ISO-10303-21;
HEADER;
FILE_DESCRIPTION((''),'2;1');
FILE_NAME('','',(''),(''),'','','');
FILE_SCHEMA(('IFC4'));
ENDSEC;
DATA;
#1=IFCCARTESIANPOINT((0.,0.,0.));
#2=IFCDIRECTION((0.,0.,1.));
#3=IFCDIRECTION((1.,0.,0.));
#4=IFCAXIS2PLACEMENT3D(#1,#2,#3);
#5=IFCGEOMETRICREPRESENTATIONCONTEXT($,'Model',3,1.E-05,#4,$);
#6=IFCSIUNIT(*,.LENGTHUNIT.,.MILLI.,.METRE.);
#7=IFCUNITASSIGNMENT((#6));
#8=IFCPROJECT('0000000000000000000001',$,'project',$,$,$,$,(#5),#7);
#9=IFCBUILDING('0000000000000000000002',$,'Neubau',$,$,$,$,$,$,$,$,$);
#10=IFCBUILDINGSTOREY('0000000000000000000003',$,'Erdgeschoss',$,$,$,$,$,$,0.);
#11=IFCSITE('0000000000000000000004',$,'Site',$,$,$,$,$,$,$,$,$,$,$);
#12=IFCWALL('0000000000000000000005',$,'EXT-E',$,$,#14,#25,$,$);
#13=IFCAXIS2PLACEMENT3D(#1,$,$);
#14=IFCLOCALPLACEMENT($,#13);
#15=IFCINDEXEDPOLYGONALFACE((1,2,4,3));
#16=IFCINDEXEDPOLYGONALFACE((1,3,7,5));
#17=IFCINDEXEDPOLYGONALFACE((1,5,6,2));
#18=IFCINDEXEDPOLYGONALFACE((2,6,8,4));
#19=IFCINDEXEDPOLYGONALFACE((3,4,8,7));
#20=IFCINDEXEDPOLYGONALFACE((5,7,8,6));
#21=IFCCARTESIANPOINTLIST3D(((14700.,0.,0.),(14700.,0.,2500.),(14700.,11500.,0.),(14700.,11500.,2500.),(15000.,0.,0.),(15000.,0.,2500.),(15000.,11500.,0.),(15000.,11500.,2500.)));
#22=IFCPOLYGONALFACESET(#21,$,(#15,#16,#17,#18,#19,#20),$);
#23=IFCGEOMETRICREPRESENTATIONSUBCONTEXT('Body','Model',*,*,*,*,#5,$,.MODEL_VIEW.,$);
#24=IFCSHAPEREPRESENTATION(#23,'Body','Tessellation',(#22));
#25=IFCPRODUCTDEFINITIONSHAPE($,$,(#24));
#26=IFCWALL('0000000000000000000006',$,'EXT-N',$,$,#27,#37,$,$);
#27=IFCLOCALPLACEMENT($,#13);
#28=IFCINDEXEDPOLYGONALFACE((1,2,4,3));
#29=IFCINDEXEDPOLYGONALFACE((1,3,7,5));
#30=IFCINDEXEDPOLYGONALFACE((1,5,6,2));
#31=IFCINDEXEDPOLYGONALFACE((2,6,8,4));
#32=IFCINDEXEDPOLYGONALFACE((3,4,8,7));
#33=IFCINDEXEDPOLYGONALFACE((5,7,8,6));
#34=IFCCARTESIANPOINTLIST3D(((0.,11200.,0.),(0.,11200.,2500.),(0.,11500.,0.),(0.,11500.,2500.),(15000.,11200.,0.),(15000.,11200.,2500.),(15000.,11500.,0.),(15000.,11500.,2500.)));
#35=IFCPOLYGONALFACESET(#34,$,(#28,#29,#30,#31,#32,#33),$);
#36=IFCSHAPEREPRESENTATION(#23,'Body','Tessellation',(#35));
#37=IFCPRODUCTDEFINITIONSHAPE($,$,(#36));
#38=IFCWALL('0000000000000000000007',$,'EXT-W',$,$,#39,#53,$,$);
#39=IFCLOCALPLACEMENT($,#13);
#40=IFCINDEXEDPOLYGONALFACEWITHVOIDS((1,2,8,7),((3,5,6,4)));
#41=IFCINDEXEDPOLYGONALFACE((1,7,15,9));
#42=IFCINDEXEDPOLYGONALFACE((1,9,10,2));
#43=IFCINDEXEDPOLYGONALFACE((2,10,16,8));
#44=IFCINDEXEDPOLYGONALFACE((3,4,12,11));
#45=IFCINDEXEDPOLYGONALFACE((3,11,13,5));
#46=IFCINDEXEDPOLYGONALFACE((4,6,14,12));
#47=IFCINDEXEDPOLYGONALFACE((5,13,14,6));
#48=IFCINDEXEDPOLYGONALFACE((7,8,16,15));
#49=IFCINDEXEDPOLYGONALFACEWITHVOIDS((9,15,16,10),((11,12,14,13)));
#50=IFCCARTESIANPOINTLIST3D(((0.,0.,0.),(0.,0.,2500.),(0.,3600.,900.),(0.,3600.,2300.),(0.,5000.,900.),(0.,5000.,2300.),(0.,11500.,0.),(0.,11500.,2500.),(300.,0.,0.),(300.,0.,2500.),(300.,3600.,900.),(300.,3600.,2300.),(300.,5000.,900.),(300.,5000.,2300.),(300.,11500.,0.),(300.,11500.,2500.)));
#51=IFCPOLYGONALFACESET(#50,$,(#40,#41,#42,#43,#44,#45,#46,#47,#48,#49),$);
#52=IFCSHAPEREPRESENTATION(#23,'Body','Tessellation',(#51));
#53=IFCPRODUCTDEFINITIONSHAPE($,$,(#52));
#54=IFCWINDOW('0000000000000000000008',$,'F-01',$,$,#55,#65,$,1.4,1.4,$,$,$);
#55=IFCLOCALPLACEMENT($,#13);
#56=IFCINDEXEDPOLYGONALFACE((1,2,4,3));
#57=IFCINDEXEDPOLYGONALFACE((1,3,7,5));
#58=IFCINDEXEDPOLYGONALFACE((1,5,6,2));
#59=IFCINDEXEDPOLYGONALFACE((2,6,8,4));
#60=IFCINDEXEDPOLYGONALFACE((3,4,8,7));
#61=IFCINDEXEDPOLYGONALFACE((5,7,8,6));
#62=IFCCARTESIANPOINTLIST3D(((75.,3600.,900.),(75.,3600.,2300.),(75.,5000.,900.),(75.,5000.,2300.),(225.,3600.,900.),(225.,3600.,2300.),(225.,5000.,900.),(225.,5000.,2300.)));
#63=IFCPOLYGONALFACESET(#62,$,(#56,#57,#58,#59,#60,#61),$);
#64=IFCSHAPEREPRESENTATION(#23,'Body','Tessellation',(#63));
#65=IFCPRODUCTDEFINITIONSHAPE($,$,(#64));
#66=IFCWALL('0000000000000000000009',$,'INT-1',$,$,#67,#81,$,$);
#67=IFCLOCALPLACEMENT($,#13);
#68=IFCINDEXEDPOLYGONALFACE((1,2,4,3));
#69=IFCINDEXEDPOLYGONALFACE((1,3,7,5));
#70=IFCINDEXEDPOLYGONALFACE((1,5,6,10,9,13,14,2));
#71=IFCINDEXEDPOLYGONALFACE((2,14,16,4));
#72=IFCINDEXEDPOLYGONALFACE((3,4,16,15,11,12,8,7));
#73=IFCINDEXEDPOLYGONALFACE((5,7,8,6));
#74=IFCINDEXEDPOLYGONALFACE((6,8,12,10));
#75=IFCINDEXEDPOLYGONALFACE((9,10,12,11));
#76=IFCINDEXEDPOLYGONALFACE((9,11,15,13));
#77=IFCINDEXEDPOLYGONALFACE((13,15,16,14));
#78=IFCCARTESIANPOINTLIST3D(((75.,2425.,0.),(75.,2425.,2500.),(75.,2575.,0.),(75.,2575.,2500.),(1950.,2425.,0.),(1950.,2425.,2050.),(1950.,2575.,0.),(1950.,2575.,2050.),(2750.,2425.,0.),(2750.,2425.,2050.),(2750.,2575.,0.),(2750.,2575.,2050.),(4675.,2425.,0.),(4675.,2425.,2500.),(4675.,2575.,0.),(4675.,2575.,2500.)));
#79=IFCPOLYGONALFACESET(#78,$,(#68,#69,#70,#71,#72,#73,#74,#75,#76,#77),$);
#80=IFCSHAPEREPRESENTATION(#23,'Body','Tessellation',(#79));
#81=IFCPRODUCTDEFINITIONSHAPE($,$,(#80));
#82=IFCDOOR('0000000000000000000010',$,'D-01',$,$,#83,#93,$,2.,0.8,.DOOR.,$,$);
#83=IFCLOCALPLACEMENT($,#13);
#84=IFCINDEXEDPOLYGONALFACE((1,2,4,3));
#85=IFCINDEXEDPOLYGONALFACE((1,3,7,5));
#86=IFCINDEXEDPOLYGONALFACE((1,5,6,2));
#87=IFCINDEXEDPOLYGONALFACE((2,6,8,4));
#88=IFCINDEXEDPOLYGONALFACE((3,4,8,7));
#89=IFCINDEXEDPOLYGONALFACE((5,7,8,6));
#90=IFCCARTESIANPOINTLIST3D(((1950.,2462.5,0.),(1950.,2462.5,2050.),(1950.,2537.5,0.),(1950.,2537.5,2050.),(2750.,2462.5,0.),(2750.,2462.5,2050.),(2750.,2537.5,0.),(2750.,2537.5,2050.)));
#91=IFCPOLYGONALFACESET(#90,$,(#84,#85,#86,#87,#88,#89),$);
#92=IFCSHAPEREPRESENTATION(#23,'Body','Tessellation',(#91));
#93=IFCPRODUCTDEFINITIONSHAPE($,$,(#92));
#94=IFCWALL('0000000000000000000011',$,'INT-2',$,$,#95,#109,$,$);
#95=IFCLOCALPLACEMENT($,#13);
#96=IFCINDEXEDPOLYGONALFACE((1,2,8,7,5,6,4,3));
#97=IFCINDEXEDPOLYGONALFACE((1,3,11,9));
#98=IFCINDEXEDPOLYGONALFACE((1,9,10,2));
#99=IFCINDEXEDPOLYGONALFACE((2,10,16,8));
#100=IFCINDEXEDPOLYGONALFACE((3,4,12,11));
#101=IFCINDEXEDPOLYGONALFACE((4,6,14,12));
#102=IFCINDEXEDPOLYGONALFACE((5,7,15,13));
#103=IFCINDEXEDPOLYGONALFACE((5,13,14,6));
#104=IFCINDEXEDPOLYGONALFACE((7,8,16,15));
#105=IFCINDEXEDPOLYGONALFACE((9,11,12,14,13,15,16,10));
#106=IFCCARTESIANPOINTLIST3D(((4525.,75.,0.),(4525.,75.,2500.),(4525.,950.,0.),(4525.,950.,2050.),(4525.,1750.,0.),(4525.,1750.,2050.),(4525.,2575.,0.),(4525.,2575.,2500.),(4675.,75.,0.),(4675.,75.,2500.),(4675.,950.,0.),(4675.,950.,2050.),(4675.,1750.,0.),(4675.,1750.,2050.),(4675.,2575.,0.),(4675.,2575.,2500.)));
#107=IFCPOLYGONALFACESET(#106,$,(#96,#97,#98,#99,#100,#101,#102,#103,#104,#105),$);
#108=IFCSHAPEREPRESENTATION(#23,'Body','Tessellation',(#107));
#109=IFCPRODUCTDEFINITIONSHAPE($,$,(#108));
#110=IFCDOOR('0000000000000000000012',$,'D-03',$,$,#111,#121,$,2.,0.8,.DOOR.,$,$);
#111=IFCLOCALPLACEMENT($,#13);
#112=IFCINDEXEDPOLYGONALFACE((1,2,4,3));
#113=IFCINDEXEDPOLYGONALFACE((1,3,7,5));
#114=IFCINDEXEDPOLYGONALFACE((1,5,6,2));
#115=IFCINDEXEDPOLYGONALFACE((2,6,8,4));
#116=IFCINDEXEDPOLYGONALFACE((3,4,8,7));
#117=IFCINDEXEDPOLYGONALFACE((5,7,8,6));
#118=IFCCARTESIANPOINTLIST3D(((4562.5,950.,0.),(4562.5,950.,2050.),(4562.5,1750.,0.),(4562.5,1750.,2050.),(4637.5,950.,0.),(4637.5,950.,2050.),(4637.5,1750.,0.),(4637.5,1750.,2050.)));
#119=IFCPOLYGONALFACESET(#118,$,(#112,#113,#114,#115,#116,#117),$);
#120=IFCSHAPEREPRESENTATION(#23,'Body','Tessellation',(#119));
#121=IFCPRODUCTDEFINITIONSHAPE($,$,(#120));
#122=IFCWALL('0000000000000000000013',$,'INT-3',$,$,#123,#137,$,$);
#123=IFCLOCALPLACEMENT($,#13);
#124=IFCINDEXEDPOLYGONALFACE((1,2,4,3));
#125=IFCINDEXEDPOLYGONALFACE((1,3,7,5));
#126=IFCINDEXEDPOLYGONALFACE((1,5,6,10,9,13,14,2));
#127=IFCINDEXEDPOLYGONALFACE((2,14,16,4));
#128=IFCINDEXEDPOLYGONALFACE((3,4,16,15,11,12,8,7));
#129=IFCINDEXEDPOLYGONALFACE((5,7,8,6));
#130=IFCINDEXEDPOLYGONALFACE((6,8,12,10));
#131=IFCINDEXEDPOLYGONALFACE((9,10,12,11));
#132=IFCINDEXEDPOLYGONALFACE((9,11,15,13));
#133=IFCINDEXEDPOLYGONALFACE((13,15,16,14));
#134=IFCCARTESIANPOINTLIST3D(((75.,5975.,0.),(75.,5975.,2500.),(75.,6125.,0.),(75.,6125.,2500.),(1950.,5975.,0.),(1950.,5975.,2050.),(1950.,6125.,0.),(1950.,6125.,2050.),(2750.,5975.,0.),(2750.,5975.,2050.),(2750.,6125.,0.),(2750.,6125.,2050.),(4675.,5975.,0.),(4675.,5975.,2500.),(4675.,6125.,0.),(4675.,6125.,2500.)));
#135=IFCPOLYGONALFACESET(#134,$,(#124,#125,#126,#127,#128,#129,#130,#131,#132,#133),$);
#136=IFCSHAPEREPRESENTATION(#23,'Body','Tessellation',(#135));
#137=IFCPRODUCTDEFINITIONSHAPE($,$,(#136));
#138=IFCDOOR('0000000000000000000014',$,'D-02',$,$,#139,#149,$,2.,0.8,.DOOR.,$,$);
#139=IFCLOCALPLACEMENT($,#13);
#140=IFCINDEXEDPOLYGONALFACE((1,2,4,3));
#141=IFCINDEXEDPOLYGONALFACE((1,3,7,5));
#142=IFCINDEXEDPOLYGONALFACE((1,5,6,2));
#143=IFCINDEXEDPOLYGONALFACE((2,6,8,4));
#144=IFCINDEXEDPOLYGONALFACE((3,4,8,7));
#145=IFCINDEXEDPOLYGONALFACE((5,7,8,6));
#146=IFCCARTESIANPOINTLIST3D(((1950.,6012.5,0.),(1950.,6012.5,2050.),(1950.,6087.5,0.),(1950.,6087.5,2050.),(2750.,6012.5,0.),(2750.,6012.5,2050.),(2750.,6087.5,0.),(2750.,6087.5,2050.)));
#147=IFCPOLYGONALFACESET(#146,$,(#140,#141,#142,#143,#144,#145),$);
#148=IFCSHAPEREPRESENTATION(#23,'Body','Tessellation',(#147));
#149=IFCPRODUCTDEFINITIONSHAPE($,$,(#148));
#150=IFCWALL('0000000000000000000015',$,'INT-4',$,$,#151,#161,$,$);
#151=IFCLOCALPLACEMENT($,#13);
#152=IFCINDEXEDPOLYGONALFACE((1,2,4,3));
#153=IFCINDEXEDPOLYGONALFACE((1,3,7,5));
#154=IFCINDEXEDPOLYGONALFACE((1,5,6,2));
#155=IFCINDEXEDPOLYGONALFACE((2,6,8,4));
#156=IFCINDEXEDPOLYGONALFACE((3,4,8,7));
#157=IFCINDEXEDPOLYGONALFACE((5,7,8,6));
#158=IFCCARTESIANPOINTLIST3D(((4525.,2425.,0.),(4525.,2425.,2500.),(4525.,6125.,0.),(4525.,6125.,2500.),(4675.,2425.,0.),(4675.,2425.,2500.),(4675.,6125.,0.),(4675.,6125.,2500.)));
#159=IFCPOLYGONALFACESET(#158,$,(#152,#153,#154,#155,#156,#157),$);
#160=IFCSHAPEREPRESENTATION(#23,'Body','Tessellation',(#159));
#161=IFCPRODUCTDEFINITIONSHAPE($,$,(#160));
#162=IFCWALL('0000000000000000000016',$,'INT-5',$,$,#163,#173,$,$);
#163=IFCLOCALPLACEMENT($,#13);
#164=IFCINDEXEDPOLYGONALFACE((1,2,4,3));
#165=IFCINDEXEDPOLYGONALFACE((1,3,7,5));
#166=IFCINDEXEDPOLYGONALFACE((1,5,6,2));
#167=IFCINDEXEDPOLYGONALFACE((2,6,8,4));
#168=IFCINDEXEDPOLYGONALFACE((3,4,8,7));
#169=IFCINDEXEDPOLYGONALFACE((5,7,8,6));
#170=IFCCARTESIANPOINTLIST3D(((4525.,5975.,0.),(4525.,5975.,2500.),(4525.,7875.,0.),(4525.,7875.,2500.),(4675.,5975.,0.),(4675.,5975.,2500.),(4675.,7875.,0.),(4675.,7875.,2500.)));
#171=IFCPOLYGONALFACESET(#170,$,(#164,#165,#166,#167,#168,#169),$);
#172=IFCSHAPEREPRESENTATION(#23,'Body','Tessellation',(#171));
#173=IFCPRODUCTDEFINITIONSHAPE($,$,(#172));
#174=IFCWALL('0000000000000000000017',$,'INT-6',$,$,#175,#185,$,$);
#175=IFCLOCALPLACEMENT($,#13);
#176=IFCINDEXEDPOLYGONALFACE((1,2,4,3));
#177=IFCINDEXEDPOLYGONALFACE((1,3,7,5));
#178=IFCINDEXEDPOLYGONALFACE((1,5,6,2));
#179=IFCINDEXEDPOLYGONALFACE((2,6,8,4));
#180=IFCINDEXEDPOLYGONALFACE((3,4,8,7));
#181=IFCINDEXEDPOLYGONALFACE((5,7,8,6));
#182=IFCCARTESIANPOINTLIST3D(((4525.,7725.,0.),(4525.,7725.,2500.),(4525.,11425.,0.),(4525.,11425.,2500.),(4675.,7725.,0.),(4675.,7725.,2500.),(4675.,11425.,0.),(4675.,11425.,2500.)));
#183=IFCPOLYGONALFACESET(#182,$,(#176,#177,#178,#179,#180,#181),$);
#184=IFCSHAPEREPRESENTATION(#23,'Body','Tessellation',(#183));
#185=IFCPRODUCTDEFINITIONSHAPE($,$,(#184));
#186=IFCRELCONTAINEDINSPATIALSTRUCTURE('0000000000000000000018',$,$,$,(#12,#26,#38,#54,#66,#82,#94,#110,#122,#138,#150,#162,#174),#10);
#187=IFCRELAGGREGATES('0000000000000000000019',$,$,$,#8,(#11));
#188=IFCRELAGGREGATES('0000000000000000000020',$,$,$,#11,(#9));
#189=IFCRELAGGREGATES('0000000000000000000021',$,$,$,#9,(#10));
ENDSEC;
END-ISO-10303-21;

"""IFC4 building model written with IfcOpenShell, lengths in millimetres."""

from ifc_helpers import new_model, si_unit, frame, origin_with_axes, place, context, subcontext, project, spatial, indexed_curve, outline, extrude, element, fill, save


model = new_model("IFC4")

# Units and contexts
model_context = context("Model", 3, precision=1e-05, world=origin_with_axes())
body_context = subcontext(model_context, "Body", "Model", "MODEL_VIEW")
ifc_project = project(units=[si_unit("LENGTHUNIT", "METRE", prefix="MILLI")], contexts=[model_context])

# Site, building, storey
site = spatial("IfcSite", under=ifc_project, Name="Site")
building = spatial("IfcBuilding", under=site, Name="Neubau")
storey = spatial("IfcBuildingStorey", under=building, Name="Erdgeschoss", Elevation=0.0)

# Walls
wall_1_placement = place(None, origin_with_axes())
element("IfcWall", 1, at=wall_1_placement, inside=storey, Name="EXT-E", context=body_context, shape_type="SweptSolid", body=[
    extrude(outline(indexed_curve([(14700.0, 0.0), (14700.0, 11500.0), (15000.0, 11500.0), (15000.0, 0.0), (14700.0, 0.0)])), origin_with_axes(), (0.0, 0.0, 1.0), 2500.0),
])
wall_2_placement = place(None, origin_with_axes())
element("IfcWall", 2, at=wall_2_placement, inside=storey, Name="EXT-N", context=body_context, shape_type="SweptSolid", body=[
    extrude(outline(indexed_curve([(15000.0, 11200.0), (0.0, 11200.0), (0.0, 11500.0), (15000.0, 11500.0), (15000.0, 11200.0)])), origin_with_axes(), (0.0, 0.0, 1.0), 2500.0),
])

# Wall, opening, window
wall_3_placement = place(None, origin_with_axes())
wall_3 = element("IfcWall", 3, at=wall_3_placement, inside=storey, Name="EXT-W", context=body_context, shape_type="SweptSolid", body=[
    extrude(outline(indexed_curve([(300.0, 11500.0), (300.0, 0.0), (0.0, 0.0), (0.0, 11500.0), (300.0, 11500.0)])), origin_with_axes(), (0.0, 0.0, 1.0), 2500.0),
])
opening_1_placement = place(wall_3_placement, frame((0.0, 0.0, 900.0), z_axis=(0.0, 0.0, 1.0), x_axis=(1.0, 0.0, 0.0)))
opening_1 = element("IfcOpeningElement", 4, at=opening_1_placement, cuts=wall_3, context=body_context, shape_type="SweptSolid", body=[
    extrude(outline(indexed_curve([(320.0, 5000.0), (320.0, 3600.0), (-20.0, 3600.0), (-20.0, 5000.0), (320.0, 5000.0)])), origin_with_axes(), (0.0, 0.0, 1.0), 1400.0),
])
window_1_placement = place(opening_1_placement, origin_with_axes())
window_1 = element("IfcWindow", 5, at=window_1_placement, inside=storey, Name="F-01", OverallHeight=1.4, OverallWidth=1.4, context=body_context, shape_type="SweptSolid", body=[
    extrude(outline(indexed_curve([(225.0, 5000.0), (225.0, 3600.0), (75.0, 3600.0), (75.0, 5000.0), (225.0, 5000.0)])), origin_with_axes(), (0.0, 0.0, 1.0), 1400.0),
])
fill(opening_1, window_1)

# Walls, openings, doors
wall_4_placement = place(None, origin_with_axes())
wall_4 = element("IfcWall", 6, at=wall_4_placement, inside=storey, Name="INT-1", context=body_context, shape_type="SweptSolid", body=[
    extrude(outline(indexed_curve([(75.0, 2575.0), (4675.0, 2575.0), (4675.0, 2425.0), (75.0, 2425.0), (75.0, 2575.0)])), origin_with_axes(), (0.0, 0.0, 1.0), 2500.0),
])
opening_2_placement = place(wall_4_placement, origin_with_axes())
opening_2 = element("IfcOpeningElement", 7, at=opening_2_placement, cuts=wall_4, context=body_context, shape_type="SweptSolid", body=[
    extrude(outline(indexed_curve([(1950.0, 2595.0), (2750.0, 2595.0), (2750.0, 2405.0), (1950.0, 2405.0), (1950.0, 2595.0)])), origin_with_axes(), (0.0, 0.0, 1.0), 2050.0),
])
door_1_placement = place(opening_2_placement, origin_with_axes())
door_1 = element("IfcDoor", 8, at=door_1_placement, inside=storey, Name="D-01", OverallHeight=2.0, OverallWidth=0.8, PredefinedType="DOOR", context=body_context, shape_type="SweptSolid", body=[
    extrude(outline(indexed_curve([(1950.0, 2537.5), (2750.0, 2537.5), (2750.0, 2462.5), (1950.0, 2462.5), (1950.0, 2537.5)])), origin_with_axes(), (0.0, 0.0, 1.0), 2050.0),
])
fill(opening_2, door_1)
wall_5_placement = place(None, origin_with_axes())
wall_5 = element("IfcWall", 9, at=wall_5_placement, inside=storey, Name="INT-2", context=body_context, shape_type="SweptSolid", body=[
    extrude(outline(indexed_curve([(4525.0, 75.0), (4525.0, 2575.0), (4675.0, 2575.0), (4675.0, 75.0), (4525.0, 75.0)])), origin_with_axes(), (0.0, 0.0, 1.0), 2500.0),
])
opening_3_placement = place(wall_5_placement, origin_with_axes())
opening_3 = element("IfcOpeningElement", 10, at=opening_3_placement, cuts=wall_5, context=body_context, shape_type="SweptSolid", body=[
    extrude(outline(indexed_curve([(4505.0, 950.0), (4505.0, 1750.0), (4695.0, 1750.0), (4695.0, 950.0), (4505.0, 950.0)])), origin_with_axes(), (0.0, 0.0, 1.0), 2050.0),
])
door_2_placement = place(opening_3_placement, origin_with_axes())
door_2 = element("IfcDoor", 11, at=door_2_placement, inside=storey, Name="D-03", OverallHeight=2.0, OverallWidth=0.8, PredefinedType="DOOR", context=body_context, shape_type="SweptSolid", body=[
    extrude(outline(indexed_curve([(4562.5, 950.0), (4562.5, 1750.0), (4637.5, 1750.0), (4637.5, 950.0), (4562.5, 950.0)])), origin_with_axes(), (0.0, 0.0, 1.0), 2050.0),
])
fill(opening_3, door_2)
wall_6_placement = place(None, origin_with_axes())
wall_6 = element("IfcWall", 12, at=wall_6_placement, inside=storey, Name="INT-3", context=body_context, shape_type="SweptSolid", body=[
    extrude(outline(indexed_curve([(75.0, 6125.0), (4675.0, 6125.0), (4675.0, 5975.0), (75.0, 5975.0), (75.0, 6125.0)])), origin_with_axes(), (0.0, 0.0, 1.0), 2500.0),
])
opening_4_placement = place(wall_6_placement, origin_with_axes())
opening_4 = element("IfcOpeningElement", 13, at=opening_4_placement, cuts=wall_6, context=body_context, shape_type="SweptSolid", body=[
    extrude(outline(indexed_curve([(1950.0, 6145.0), (2750.0, 6145.0), (2750.0, 5955.0), (1950.0, 5955.0), (1950.0, 6145.0)])), origin_with_axes(), (0.0, 0.0, 1.0), 2050.0),
])
door_3_placement = place(opening_4_placement, origin_with_axes())
door_3 = element("IfcDoor", 14, at=door_3_placement, inside=storey, Name="D-02", OverallHeight=2.0, OverallWidth=0.8, PredefinedType="DOOR", context=body_context, shape_type="SweptSolid", body=[
    extrude(outline(indexed_curve([(1950.0, 6087.5), (2750.0, 6087.5), (2750.0, 6012.5), (1950.0, 6012.5), (1950.0, 6087.5)])), origin_with_axes(), (0.0, 0.0, 1.0), 2050.0),
])
fill(opening_4, door_3)

# Walls
wall_7_placement = place(None, origin_with_axes())
element("IfcWall", 15, at=wall_7_placement, inside=storey, Name="INT-4", context=body_context, shape_type="SweptSolid", body=[
    extrude(outline(indexed_curve([(4525.0, 2425.0), (4525.0, 6125.0), (4675.0, 6125.0), (4675.0, 2425.0), (4525.0, 2425.0)])), origin_with_axes(), (0.0, 0.0, 1.0), 2500.0),
])
wall_8_placement = place(None, origin_with_axes())
element("IfcWall", 16, at=wall_8_placement, inside=storey, Name="INT-5", context=body_context, shape_type="SweptSolid", body=[
    extrude(outline(indexed_curve([(4525.0, 5975.0), (4525.0, 7875.0), (4675.0, 7875.0), (4675.0, 5975.0), (4525.0, 5975.0)])), origin_with_axes(), (0.0, 0.0, 1.0), 2500.0),
])
wall_9_placement = place(None, origin_with_axes())
element("IfcWall", 17, at=wall_9_placement, inside=storey, Name="INT-6", context=body_context, shape_type="SweptSolid", body=[
    extrude(outline(indexed_curve([(4525.0, 7725.0), (4525.0, 11425.0), (4675.0, 11425.0), (4675.0, 7725.0), (4525.0, 7725.0)])), origin_with_axes(), (0.0, 0.0, 1.0), 2500.0),
])

save(model, "model.ifc")
